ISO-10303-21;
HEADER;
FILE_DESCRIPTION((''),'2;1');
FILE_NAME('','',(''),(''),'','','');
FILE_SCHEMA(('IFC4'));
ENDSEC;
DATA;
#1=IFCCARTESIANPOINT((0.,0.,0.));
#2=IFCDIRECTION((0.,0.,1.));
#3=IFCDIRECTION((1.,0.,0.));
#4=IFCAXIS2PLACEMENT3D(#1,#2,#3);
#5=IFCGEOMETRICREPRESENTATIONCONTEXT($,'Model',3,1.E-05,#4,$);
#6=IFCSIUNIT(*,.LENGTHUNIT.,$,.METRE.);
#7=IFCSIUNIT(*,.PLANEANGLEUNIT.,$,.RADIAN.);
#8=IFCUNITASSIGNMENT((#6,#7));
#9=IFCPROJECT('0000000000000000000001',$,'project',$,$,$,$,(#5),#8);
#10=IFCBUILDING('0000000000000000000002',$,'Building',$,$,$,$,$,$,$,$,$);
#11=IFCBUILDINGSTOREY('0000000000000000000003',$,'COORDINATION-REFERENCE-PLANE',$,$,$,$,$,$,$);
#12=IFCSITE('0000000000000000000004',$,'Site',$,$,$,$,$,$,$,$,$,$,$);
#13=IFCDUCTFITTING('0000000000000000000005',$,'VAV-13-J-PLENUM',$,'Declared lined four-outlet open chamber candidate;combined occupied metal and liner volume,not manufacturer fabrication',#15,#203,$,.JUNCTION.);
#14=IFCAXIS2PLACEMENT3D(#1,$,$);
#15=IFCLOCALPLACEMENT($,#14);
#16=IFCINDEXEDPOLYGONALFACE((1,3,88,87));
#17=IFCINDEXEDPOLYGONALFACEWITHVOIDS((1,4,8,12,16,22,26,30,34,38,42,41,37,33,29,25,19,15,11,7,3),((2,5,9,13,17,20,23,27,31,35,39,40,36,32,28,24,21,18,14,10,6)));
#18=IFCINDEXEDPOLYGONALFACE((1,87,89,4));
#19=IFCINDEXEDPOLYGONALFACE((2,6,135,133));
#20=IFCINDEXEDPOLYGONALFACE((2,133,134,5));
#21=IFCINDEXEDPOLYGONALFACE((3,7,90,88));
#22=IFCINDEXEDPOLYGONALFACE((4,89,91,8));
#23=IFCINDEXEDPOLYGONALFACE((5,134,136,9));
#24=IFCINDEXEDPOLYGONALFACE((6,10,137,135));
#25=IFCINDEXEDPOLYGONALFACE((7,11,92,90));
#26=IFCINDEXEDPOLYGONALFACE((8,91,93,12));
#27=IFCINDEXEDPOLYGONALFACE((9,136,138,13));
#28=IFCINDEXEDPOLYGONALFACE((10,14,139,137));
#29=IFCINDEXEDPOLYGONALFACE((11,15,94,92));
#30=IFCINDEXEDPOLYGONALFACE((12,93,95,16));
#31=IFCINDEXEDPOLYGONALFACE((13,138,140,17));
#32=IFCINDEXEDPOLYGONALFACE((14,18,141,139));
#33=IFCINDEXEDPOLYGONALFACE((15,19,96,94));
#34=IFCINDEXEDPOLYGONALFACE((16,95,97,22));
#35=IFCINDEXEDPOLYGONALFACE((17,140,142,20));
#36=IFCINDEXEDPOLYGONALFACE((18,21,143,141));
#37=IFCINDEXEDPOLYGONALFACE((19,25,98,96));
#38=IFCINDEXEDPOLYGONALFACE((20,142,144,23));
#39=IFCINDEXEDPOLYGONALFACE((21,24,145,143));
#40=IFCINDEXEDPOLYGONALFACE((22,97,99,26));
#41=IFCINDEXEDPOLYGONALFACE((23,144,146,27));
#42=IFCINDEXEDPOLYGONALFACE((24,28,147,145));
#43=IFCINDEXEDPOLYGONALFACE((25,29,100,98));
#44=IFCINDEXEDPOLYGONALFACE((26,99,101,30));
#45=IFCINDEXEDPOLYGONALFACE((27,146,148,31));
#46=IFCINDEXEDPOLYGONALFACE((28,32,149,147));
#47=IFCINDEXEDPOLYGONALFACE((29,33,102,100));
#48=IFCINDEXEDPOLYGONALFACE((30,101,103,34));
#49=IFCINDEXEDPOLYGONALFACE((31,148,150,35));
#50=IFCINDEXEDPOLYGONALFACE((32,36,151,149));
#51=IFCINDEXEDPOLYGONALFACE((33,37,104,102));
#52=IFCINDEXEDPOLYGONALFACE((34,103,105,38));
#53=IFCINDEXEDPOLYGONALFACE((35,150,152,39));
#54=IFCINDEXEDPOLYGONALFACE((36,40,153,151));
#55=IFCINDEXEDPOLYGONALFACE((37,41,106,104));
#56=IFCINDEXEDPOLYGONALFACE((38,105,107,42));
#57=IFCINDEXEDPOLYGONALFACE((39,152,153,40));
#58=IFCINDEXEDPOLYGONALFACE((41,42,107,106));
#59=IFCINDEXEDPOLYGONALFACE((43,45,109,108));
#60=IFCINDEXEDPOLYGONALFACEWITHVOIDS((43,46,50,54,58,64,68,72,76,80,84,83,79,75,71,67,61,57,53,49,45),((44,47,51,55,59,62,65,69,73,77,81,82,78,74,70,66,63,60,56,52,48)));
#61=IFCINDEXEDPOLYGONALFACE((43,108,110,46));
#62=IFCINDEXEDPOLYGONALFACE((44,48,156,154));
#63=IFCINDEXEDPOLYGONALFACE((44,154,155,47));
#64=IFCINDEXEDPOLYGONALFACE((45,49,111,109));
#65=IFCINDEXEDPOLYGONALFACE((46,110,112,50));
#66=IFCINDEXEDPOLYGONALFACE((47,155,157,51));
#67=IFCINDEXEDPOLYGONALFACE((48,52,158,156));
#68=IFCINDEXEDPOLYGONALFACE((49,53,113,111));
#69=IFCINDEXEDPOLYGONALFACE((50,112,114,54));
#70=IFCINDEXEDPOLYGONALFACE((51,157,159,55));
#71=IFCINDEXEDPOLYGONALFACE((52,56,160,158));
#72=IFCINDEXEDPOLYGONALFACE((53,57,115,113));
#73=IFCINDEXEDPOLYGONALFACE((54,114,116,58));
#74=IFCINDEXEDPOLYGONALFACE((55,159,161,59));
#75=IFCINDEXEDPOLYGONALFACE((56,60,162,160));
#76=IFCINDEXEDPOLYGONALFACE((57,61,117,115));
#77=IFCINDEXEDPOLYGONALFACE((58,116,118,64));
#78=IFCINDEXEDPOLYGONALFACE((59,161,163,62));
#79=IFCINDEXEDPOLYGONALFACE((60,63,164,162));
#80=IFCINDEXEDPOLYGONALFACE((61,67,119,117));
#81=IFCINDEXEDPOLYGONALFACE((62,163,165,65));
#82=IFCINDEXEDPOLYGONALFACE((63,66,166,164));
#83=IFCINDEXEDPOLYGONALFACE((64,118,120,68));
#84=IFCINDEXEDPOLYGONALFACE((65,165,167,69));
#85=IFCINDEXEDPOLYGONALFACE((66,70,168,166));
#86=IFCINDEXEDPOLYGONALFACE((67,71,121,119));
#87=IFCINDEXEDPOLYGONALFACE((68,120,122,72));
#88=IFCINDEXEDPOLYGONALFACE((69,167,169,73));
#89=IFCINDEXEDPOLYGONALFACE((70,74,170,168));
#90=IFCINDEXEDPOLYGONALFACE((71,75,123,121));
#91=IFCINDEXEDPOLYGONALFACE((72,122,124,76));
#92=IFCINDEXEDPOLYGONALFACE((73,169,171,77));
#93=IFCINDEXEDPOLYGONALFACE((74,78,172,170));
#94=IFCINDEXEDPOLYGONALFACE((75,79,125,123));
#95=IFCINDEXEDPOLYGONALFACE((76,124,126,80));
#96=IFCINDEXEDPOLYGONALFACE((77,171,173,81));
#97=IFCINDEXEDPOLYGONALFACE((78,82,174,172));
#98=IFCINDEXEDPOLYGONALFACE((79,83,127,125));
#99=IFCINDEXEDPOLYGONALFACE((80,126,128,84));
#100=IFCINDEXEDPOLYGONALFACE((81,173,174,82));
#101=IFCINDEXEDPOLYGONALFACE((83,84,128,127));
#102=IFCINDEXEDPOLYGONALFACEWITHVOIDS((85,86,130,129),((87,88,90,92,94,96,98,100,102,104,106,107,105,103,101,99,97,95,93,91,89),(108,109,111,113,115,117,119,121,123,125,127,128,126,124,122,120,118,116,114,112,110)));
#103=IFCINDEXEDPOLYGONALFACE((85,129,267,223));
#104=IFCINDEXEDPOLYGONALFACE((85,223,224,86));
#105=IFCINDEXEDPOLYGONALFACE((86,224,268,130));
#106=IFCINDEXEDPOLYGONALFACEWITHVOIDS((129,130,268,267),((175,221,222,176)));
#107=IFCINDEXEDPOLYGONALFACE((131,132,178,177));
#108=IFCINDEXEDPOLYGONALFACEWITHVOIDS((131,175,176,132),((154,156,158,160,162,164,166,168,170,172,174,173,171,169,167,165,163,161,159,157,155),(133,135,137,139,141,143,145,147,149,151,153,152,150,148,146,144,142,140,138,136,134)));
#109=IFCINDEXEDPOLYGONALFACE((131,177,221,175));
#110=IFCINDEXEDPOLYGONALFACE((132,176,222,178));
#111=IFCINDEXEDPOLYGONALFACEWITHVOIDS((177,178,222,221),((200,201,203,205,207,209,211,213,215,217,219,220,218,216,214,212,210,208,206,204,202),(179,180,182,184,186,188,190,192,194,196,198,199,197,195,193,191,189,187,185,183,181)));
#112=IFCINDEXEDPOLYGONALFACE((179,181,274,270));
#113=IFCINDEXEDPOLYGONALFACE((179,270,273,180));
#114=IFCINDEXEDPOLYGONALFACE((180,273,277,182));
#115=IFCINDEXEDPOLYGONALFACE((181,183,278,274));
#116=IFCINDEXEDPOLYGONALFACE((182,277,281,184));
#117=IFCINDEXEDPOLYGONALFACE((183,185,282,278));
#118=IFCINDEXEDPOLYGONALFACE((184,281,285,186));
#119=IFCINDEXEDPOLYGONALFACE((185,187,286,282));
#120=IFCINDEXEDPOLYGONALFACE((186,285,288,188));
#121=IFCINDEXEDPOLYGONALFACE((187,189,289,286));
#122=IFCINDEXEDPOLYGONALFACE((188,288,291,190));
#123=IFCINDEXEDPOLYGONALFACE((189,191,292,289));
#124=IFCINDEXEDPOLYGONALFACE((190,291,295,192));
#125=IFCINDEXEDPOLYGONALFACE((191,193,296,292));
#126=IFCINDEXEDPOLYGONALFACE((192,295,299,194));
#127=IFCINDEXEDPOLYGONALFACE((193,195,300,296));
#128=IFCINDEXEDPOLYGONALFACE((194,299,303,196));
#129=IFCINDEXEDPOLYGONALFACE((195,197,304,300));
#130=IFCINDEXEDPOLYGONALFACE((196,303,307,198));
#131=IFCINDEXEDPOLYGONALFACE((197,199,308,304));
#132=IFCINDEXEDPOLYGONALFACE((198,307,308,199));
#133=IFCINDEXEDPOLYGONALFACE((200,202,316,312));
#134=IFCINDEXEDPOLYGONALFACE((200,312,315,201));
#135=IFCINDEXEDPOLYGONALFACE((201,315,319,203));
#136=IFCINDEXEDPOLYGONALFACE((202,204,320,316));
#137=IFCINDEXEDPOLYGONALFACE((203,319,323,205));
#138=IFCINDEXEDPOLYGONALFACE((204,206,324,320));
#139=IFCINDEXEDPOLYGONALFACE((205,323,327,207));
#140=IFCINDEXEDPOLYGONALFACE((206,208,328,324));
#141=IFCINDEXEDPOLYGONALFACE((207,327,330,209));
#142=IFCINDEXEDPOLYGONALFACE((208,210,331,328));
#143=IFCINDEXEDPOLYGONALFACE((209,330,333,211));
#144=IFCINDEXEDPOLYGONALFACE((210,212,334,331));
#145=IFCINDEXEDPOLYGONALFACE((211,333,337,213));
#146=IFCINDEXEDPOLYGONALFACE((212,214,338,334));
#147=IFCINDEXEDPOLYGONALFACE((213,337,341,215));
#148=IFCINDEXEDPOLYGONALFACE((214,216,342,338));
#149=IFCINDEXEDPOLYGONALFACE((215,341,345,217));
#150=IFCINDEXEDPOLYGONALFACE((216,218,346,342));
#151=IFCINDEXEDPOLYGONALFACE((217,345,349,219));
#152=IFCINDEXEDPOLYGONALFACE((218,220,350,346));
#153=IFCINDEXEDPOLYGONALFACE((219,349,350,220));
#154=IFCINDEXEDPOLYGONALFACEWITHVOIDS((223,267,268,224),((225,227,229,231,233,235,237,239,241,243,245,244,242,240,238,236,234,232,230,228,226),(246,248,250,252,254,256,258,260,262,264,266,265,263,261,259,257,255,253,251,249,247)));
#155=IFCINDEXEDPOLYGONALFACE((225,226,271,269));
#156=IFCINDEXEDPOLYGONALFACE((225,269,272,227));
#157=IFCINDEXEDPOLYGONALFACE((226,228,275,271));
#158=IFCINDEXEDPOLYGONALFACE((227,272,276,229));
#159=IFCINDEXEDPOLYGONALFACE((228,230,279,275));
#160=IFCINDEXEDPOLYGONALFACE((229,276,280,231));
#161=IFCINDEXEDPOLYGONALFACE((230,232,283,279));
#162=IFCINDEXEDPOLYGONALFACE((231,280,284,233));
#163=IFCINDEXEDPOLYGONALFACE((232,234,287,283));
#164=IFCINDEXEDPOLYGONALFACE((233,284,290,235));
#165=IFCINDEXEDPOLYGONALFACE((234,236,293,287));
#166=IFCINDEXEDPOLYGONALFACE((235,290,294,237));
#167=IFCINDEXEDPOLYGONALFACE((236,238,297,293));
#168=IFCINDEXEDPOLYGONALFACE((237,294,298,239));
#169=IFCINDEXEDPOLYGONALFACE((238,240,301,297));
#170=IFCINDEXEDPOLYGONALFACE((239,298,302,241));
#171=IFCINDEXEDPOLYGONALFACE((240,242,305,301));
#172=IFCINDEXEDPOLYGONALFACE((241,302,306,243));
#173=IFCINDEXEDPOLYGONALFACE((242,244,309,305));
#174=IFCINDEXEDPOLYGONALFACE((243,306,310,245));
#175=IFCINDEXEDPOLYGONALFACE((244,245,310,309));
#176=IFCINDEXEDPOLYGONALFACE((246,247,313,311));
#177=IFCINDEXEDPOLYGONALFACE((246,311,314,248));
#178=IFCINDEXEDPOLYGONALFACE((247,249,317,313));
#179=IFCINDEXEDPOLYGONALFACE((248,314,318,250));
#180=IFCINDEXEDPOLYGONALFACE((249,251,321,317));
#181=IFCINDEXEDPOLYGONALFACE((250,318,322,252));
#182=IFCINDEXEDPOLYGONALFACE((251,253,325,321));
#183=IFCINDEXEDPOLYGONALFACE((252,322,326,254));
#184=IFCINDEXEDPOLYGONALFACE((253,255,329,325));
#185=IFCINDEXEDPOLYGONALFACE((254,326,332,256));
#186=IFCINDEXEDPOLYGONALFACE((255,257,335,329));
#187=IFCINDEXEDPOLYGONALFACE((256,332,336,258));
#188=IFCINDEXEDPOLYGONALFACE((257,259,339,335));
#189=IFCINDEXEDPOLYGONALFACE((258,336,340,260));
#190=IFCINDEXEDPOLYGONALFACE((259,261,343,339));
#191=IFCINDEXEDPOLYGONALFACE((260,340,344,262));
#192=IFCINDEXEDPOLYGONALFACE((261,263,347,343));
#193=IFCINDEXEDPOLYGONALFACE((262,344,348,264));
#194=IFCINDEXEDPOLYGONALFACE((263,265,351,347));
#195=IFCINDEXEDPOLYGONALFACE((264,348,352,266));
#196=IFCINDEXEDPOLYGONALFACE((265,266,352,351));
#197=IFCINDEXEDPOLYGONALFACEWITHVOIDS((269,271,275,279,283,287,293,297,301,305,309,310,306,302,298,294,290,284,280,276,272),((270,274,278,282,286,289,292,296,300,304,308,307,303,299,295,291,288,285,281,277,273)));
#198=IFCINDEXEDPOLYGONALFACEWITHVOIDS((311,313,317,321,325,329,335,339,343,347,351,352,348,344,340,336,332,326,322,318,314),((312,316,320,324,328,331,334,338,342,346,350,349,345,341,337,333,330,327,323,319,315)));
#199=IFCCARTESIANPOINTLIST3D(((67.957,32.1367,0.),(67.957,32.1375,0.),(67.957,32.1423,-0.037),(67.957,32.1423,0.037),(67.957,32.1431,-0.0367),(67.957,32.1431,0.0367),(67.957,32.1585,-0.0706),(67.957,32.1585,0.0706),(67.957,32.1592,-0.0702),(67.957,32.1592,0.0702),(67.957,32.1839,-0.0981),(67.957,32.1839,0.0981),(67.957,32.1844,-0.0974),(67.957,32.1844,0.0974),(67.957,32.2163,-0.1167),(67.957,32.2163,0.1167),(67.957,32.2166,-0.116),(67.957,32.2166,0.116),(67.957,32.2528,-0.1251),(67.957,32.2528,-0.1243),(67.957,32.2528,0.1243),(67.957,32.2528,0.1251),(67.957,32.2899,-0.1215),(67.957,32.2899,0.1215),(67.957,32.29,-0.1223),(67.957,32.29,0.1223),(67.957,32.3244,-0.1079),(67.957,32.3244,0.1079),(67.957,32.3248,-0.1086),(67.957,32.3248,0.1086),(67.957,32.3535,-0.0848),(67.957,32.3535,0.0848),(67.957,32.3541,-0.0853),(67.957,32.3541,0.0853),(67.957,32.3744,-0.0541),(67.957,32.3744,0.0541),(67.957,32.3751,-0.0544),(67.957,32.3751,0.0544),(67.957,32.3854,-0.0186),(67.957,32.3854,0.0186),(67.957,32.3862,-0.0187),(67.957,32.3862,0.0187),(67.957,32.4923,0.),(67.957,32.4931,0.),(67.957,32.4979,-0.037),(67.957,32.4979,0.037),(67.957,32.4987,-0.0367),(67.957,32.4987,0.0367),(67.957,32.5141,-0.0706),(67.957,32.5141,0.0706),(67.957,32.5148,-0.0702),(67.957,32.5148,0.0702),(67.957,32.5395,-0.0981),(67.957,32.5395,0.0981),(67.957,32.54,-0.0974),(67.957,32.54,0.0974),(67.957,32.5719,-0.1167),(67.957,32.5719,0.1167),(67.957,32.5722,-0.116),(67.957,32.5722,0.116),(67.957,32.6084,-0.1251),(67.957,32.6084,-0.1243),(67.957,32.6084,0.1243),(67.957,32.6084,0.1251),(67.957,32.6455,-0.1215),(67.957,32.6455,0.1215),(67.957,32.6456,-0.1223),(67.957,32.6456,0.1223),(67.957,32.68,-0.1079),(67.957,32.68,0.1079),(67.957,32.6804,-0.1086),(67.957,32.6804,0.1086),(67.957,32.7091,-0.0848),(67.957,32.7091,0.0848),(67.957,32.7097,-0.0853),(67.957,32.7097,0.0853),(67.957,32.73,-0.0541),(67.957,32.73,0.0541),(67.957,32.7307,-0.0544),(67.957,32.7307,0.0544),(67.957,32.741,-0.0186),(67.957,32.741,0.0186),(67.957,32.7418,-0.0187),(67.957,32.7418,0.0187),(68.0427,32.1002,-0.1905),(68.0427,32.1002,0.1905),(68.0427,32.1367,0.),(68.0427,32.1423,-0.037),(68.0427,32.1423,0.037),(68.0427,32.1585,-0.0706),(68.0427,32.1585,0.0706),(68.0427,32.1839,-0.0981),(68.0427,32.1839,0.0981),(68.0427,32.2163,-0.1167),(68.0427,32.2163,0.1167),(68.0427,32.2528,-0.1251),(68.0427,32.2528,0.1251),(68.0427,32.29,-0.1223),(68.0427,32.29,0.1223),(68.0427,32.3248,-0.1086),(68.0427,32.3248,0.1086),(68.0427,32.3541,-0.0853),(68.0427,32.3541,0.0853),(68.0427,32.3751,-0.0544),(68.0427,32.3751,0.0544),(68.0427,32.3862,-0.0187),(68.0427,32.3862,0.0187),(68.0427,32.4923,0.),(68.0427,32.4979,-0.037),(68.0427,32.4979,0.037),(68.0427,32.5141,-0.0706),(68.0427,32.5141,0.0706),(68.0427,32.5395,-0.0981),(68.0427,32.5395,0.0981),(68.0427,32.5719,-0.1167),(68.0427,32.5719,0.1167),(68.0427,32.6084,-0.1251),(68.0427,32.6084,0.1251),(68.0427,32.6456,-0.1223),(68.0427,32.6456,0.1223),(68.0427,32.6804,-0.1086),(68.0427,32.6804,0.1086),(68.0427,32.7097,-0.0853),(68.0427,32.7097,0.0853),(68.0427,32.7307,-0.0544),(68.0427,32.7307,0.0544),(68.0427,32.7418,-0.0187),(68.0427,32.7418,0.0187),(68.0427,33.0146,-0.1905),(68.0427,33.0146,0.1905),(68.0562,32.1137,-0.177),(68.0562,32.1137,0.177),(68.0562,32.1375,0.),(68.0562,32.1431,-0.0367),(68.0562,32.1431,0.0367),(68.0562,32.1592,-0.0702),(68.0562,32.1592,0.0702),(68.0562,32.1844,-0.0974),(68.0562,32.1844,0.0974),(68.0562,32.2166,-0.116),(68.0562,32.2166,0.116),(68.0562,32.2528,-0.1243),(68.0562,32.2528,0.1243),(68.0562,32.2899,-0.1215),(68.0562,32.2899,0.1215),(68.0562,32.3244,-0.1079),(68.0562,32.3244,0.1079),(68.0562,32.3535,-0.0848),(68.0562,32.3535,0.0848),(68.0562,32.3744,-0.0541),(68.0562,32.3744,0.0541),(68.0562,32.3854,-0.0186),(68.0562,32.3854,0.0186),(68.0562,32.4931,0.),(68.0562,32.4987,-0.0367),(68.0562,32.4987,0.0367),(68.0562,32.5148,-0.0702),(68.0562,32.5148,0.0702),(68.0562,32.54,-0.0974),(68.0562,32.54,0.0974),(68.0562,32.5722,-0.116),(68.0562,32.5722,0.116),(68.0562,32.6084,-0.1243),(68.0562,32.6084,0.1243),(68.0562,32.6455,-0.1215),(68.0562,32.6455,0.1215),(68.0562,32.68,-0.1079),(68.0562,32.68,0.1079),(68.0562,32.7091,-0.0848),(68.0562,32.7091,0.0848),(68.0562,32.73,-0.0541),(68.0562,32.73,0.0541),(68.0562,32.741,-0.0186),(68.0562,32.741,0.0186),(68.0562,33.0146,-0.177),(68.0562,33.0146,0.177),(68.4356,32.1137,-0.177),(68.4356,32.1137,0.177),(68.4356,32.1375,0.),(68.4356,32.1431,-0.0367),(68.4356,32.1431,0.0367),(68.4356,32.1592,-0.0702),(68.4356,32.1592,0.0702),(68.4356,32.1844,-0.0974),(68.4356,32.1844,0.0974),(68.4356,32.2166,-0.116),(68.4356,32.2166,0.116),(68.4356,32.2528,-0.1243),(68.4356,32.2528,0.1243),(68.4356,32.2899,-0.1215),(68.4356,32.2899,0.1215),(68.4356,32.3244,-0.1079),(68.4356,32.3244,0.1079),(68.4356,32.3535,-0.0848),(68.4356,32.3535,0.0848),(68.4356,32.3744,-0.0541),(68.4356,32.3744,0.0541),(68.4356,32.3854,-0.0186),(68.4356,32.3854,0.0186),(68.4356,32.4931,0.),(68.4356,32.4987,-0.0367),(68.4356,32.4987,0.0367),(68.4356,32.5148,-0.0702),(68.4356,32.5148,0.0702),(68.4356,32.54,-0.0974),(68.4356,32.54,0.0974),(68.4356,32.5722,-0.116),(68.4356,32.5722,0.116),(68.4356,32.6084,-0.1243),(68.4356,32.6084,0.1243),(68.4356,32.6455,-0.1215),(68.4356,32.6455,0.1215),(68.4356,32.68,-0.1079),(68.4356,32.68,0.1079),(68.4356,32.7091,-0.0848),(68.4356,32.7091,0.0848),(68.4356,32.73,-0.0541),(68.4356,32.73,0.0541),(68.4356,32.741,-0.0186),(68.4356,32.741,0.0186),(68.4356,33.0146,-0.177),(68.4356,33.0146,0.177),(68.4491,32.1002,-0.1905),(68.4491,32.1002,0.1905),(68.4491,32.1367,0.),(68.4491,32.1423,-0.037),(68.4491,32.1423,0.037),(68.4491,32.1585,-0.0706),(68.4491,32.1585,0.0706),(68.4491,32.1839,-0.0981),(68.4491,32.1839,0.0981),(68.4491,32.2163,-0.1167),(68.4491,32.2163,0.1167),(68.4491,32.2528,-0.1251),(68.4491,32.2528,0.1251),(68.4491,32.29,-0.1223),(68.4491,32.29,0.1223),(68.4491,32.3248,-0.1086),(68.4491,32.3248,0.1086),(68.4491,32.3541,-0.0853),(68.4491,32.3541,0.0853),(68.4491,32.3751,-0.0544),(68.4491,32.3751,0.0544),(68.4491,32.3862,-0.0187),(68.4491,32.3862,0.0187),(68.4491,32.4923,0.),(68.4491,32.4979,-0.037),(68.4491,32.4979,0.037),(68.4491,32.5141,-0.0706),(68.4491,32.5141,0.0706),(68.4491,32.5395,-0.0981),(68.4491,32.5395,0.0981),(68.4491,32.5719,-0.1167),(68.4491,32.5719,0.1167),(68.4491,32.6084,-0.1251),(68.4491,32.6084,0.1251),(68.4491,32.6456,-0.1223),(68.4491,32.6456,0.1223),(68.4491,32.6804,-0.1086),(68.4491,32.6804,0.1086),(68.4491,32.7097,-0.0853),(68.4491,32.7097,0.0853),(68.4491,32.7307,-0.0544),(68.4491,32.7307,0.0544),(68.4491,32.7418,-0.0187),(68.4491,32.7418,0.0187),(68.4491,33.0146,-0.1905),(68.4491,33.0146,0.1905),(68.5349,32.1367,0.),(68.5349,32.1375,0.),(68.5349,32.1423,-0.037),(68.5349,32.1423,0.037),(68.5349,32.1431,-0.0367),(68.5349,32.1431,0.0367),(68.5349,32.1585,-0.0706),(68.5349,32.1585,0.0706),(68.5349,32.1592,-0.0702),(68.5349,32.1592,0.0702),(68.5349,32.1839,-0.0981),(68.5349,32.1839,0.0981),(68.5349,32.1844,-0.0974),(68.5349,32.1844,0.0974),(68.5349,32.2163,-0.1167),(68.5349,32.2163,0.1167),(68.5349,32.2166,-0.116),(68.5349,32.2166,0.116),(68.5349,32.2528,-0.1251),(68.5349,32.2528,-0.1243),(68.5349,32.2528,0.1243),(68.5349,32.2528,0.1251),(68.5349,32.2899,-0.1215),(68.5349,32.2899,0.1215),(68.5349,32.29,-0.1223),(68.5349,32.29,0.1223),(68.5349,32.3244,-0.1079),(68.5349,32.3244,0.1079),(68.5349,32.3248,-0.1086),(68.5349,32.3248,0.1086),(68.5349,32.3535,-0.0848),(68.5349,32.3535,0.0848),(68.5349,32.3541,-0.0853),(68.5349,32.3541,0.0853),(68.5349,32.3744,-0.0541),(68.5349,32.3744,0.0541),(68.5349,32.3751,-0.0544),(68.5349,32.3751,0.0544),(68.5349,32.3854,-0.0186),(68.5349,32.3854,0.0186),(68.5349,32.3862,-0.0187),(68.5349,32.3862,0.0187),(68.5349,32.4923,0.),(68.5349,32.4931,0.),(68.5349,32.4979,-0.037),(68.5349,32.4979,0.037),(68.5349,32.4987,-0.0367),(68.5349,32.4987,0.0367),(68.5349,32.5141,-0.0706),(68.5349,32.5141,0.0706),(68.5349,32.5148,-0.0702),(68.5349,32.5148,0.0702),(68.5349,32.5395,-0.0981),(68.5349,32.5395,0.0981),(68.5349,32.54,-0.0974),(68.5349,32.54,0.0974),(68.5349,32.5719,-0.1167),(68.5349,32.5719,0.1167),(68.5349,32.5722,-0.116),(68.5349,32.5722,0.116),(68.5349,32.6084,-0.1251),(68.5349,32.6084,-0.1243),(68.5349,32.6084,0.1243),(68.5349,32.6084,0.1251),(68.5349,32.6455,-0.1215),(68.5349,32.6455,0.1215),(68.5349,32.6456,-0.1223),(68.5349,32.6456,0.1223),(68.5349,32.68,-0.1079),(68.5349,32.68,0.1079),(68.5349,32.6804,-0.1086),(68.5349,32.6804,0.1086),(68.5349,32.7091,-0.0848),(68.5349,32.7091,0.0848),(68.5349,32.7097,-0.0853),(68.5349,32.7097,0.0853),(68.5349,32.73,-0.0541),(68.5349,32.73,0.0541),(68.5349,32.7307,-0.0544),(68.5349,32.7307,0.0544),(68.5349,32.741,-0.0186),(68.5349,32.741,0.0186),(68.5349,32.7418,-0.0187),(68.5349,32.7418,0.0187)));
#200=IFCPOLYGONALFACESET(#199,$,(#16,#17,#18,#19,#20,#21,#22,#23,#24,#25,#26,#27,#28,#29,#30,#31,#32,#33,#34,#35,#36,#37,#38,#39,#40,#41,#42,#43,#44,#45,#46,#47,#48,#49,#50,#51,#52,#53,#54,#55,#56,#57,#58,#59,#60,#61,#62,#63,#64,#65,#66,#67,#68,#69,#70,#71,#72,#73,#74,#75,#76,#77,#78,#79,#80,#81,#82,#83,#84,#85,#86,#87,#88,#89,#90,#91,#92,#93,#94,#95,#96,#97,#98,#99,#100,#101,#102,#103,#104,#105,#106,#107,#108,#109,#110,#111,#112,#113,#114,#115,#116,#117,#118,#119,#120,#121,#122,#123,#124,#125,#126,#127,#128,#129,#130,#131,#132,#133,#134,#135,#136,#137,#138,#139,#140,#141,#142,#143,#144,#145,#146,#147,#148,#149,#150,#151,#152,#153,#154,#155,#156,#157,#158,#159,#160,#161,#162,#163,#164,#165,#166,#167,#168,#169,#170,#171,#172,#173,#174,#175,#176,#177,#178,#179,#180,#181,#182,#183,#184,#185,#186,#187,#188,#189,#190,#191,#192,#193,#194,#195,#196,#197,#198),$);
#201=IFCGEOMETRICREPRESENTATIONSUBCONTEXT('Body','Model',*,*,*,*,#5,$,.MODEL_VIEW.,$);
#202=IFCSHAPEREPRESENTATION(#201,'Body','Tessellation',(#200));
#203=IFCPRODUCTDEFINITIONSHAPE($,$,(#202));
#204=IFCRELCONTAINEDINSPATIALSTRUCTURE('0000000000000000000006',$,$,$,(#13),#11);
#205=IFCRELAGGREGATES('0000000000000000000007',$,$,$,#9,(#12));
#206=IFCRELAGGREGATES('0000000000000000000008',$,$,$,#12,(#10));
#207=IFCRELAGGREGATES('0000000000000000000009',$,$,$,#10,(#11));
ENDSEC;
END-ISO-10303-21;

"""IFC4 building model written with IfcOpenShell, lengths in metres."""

from ifc_helpers import new_model, si_unit, frame, origin_with_axes, place, context, subcontext, project, spatial, rectangle, circle, extrude, boolean, element, save


model = new_model("IFC4")

# Units and contexts
model_context = context("Model", 3, precision=1e-05, world=origin_with_axes())
body_context_1 = subcontext(model_context, "Body", "Model", "MODEL_VIEW")
ifc_project = project(units=[si_unit("LENGTHUNIT", "METRE"), si_unit("PLANEANGLEUNIT", "RADIAN")], contexts=[model_context])

# Site, building, storey
site = spatial("IfcSite", under=ifc_project, Name="Site")
building = spatial("IfcBuilding", under=site, Name="Building")
storey = spatial("IfcBuildingStorey", under=building, Name="COORDINATION-REFERENCE-PLANE")

# Duct fitting
duct_fitting_1_placement = place(None, frame((68.0427, 32.1002, -0.1905), z_axis=(0.0, 0.0, 1.0), x_axis=(1.0, 0.0, 0.0)))
solid_1 = boolean("UNION", boolean("UNION", boolean("UNION", boolean("UNION", extrude(rectangle(XDim=0.3794, YDim=0.354), frame((0.2032, 0.9244, 0.1905), z_axis=(0.0, -1.0, 0.0), x_axis=(1.0, 0.0, 0.0)), (0.0, 0.0, 1.0), 0.9109), extrude(circle(Radius=0.1246), frame((0.0235, 0.5175, 0.1905), z_axis=(-1.0, 0.0, 0.0), x_axis=(0.0, -1.0, 0.0)), (0.0, 0.0, 1.0), 0.1192)), extrude(circle(Radius=0.1246), frame((0.3829, 0.5175, 0.1905), z_axis=(1.0, 0.0, 0.0), x_axis=(0.0, -1.0, 0.0)), (0.0, 0.0, 1.0), 0.1192)), extrude(circle(Radius=0.1246), frame((0.0235, 0.1619, 0.1905), z_axis=(-1.0, 0.0, 0.0), x_axis=(0.0, -1.0, 0.0)), (0.0, 0.0, 1.0), 0.1192)), extrude(circle(Radius=0.1246), frame((0.3829, 0.1619, 0.1905), z_axis=(1.0, 0.0, 0.0), x_axis=(0.0, -1.0, 0.0)), (0.0, 0.0, 1.0), 0.1192))
element("IfcDuctFitting", 1, at=duct_fitting_1_placement, inside=storey, Name="VAV-13-J-PLENUM", ObjectType="Declared lined four-outlet open chamber candidate;combined occupied metal and liner volume,not manufacturer fabrication", PredefinedType="JUNCTION", context=body_context_1, shape_type="CSG", body=[
    boolean("DIFFERENCE", boolean("UNION", boolean("UNION", boolean("UNION", boolean("UNION", extrude(rectangle(XDim=0.4064, YDim=0.381), frame((0.2032, 0.9144, 0.1905), z_axis=(0.0, -1.0, 0.0), x_axis=(1.0, 0.0, 0.0)), (0.0, 0.0, 1.0), 0.9144), extrude(circle(Radius=0.1254), frame((0.0235, 0.5175, 0.1905), z_axis=(-1.0, 0.0, 0.0), x_axis=(0.0, -1.0, 0.0)), (0.0, 0.0, 1.0), 0.1092)), extrude(circle(Radius=0.1254), frame((0.3829, 0.5175, 0.1905), z_axis=(1.0, 0.0, 0.0), x_axis=(0.0, -1.0, 0.0)), (0.0, 0.0, 1.0), 0.1092)), extrude(circle(Radius=0.1254), frame((0.0235, 0.1619, 0.1905), z_axis=(-1.0, 0.0, 0.0), x_axis=(0.0, -1.0, 0.0)), (0.0, 0.0, 1.0), 0.1092)), extrude(circle(Radius=0.1254), frame((0.3829, 0.1619, 0.1905), z_axis=(1.0, 0.0, 0.0), x_axis=(0.0, -1.0, 0.0)), (0.0, 0.0, 1.0), 0.1092)), solid_1),
])

save(model, "model.ifc")
